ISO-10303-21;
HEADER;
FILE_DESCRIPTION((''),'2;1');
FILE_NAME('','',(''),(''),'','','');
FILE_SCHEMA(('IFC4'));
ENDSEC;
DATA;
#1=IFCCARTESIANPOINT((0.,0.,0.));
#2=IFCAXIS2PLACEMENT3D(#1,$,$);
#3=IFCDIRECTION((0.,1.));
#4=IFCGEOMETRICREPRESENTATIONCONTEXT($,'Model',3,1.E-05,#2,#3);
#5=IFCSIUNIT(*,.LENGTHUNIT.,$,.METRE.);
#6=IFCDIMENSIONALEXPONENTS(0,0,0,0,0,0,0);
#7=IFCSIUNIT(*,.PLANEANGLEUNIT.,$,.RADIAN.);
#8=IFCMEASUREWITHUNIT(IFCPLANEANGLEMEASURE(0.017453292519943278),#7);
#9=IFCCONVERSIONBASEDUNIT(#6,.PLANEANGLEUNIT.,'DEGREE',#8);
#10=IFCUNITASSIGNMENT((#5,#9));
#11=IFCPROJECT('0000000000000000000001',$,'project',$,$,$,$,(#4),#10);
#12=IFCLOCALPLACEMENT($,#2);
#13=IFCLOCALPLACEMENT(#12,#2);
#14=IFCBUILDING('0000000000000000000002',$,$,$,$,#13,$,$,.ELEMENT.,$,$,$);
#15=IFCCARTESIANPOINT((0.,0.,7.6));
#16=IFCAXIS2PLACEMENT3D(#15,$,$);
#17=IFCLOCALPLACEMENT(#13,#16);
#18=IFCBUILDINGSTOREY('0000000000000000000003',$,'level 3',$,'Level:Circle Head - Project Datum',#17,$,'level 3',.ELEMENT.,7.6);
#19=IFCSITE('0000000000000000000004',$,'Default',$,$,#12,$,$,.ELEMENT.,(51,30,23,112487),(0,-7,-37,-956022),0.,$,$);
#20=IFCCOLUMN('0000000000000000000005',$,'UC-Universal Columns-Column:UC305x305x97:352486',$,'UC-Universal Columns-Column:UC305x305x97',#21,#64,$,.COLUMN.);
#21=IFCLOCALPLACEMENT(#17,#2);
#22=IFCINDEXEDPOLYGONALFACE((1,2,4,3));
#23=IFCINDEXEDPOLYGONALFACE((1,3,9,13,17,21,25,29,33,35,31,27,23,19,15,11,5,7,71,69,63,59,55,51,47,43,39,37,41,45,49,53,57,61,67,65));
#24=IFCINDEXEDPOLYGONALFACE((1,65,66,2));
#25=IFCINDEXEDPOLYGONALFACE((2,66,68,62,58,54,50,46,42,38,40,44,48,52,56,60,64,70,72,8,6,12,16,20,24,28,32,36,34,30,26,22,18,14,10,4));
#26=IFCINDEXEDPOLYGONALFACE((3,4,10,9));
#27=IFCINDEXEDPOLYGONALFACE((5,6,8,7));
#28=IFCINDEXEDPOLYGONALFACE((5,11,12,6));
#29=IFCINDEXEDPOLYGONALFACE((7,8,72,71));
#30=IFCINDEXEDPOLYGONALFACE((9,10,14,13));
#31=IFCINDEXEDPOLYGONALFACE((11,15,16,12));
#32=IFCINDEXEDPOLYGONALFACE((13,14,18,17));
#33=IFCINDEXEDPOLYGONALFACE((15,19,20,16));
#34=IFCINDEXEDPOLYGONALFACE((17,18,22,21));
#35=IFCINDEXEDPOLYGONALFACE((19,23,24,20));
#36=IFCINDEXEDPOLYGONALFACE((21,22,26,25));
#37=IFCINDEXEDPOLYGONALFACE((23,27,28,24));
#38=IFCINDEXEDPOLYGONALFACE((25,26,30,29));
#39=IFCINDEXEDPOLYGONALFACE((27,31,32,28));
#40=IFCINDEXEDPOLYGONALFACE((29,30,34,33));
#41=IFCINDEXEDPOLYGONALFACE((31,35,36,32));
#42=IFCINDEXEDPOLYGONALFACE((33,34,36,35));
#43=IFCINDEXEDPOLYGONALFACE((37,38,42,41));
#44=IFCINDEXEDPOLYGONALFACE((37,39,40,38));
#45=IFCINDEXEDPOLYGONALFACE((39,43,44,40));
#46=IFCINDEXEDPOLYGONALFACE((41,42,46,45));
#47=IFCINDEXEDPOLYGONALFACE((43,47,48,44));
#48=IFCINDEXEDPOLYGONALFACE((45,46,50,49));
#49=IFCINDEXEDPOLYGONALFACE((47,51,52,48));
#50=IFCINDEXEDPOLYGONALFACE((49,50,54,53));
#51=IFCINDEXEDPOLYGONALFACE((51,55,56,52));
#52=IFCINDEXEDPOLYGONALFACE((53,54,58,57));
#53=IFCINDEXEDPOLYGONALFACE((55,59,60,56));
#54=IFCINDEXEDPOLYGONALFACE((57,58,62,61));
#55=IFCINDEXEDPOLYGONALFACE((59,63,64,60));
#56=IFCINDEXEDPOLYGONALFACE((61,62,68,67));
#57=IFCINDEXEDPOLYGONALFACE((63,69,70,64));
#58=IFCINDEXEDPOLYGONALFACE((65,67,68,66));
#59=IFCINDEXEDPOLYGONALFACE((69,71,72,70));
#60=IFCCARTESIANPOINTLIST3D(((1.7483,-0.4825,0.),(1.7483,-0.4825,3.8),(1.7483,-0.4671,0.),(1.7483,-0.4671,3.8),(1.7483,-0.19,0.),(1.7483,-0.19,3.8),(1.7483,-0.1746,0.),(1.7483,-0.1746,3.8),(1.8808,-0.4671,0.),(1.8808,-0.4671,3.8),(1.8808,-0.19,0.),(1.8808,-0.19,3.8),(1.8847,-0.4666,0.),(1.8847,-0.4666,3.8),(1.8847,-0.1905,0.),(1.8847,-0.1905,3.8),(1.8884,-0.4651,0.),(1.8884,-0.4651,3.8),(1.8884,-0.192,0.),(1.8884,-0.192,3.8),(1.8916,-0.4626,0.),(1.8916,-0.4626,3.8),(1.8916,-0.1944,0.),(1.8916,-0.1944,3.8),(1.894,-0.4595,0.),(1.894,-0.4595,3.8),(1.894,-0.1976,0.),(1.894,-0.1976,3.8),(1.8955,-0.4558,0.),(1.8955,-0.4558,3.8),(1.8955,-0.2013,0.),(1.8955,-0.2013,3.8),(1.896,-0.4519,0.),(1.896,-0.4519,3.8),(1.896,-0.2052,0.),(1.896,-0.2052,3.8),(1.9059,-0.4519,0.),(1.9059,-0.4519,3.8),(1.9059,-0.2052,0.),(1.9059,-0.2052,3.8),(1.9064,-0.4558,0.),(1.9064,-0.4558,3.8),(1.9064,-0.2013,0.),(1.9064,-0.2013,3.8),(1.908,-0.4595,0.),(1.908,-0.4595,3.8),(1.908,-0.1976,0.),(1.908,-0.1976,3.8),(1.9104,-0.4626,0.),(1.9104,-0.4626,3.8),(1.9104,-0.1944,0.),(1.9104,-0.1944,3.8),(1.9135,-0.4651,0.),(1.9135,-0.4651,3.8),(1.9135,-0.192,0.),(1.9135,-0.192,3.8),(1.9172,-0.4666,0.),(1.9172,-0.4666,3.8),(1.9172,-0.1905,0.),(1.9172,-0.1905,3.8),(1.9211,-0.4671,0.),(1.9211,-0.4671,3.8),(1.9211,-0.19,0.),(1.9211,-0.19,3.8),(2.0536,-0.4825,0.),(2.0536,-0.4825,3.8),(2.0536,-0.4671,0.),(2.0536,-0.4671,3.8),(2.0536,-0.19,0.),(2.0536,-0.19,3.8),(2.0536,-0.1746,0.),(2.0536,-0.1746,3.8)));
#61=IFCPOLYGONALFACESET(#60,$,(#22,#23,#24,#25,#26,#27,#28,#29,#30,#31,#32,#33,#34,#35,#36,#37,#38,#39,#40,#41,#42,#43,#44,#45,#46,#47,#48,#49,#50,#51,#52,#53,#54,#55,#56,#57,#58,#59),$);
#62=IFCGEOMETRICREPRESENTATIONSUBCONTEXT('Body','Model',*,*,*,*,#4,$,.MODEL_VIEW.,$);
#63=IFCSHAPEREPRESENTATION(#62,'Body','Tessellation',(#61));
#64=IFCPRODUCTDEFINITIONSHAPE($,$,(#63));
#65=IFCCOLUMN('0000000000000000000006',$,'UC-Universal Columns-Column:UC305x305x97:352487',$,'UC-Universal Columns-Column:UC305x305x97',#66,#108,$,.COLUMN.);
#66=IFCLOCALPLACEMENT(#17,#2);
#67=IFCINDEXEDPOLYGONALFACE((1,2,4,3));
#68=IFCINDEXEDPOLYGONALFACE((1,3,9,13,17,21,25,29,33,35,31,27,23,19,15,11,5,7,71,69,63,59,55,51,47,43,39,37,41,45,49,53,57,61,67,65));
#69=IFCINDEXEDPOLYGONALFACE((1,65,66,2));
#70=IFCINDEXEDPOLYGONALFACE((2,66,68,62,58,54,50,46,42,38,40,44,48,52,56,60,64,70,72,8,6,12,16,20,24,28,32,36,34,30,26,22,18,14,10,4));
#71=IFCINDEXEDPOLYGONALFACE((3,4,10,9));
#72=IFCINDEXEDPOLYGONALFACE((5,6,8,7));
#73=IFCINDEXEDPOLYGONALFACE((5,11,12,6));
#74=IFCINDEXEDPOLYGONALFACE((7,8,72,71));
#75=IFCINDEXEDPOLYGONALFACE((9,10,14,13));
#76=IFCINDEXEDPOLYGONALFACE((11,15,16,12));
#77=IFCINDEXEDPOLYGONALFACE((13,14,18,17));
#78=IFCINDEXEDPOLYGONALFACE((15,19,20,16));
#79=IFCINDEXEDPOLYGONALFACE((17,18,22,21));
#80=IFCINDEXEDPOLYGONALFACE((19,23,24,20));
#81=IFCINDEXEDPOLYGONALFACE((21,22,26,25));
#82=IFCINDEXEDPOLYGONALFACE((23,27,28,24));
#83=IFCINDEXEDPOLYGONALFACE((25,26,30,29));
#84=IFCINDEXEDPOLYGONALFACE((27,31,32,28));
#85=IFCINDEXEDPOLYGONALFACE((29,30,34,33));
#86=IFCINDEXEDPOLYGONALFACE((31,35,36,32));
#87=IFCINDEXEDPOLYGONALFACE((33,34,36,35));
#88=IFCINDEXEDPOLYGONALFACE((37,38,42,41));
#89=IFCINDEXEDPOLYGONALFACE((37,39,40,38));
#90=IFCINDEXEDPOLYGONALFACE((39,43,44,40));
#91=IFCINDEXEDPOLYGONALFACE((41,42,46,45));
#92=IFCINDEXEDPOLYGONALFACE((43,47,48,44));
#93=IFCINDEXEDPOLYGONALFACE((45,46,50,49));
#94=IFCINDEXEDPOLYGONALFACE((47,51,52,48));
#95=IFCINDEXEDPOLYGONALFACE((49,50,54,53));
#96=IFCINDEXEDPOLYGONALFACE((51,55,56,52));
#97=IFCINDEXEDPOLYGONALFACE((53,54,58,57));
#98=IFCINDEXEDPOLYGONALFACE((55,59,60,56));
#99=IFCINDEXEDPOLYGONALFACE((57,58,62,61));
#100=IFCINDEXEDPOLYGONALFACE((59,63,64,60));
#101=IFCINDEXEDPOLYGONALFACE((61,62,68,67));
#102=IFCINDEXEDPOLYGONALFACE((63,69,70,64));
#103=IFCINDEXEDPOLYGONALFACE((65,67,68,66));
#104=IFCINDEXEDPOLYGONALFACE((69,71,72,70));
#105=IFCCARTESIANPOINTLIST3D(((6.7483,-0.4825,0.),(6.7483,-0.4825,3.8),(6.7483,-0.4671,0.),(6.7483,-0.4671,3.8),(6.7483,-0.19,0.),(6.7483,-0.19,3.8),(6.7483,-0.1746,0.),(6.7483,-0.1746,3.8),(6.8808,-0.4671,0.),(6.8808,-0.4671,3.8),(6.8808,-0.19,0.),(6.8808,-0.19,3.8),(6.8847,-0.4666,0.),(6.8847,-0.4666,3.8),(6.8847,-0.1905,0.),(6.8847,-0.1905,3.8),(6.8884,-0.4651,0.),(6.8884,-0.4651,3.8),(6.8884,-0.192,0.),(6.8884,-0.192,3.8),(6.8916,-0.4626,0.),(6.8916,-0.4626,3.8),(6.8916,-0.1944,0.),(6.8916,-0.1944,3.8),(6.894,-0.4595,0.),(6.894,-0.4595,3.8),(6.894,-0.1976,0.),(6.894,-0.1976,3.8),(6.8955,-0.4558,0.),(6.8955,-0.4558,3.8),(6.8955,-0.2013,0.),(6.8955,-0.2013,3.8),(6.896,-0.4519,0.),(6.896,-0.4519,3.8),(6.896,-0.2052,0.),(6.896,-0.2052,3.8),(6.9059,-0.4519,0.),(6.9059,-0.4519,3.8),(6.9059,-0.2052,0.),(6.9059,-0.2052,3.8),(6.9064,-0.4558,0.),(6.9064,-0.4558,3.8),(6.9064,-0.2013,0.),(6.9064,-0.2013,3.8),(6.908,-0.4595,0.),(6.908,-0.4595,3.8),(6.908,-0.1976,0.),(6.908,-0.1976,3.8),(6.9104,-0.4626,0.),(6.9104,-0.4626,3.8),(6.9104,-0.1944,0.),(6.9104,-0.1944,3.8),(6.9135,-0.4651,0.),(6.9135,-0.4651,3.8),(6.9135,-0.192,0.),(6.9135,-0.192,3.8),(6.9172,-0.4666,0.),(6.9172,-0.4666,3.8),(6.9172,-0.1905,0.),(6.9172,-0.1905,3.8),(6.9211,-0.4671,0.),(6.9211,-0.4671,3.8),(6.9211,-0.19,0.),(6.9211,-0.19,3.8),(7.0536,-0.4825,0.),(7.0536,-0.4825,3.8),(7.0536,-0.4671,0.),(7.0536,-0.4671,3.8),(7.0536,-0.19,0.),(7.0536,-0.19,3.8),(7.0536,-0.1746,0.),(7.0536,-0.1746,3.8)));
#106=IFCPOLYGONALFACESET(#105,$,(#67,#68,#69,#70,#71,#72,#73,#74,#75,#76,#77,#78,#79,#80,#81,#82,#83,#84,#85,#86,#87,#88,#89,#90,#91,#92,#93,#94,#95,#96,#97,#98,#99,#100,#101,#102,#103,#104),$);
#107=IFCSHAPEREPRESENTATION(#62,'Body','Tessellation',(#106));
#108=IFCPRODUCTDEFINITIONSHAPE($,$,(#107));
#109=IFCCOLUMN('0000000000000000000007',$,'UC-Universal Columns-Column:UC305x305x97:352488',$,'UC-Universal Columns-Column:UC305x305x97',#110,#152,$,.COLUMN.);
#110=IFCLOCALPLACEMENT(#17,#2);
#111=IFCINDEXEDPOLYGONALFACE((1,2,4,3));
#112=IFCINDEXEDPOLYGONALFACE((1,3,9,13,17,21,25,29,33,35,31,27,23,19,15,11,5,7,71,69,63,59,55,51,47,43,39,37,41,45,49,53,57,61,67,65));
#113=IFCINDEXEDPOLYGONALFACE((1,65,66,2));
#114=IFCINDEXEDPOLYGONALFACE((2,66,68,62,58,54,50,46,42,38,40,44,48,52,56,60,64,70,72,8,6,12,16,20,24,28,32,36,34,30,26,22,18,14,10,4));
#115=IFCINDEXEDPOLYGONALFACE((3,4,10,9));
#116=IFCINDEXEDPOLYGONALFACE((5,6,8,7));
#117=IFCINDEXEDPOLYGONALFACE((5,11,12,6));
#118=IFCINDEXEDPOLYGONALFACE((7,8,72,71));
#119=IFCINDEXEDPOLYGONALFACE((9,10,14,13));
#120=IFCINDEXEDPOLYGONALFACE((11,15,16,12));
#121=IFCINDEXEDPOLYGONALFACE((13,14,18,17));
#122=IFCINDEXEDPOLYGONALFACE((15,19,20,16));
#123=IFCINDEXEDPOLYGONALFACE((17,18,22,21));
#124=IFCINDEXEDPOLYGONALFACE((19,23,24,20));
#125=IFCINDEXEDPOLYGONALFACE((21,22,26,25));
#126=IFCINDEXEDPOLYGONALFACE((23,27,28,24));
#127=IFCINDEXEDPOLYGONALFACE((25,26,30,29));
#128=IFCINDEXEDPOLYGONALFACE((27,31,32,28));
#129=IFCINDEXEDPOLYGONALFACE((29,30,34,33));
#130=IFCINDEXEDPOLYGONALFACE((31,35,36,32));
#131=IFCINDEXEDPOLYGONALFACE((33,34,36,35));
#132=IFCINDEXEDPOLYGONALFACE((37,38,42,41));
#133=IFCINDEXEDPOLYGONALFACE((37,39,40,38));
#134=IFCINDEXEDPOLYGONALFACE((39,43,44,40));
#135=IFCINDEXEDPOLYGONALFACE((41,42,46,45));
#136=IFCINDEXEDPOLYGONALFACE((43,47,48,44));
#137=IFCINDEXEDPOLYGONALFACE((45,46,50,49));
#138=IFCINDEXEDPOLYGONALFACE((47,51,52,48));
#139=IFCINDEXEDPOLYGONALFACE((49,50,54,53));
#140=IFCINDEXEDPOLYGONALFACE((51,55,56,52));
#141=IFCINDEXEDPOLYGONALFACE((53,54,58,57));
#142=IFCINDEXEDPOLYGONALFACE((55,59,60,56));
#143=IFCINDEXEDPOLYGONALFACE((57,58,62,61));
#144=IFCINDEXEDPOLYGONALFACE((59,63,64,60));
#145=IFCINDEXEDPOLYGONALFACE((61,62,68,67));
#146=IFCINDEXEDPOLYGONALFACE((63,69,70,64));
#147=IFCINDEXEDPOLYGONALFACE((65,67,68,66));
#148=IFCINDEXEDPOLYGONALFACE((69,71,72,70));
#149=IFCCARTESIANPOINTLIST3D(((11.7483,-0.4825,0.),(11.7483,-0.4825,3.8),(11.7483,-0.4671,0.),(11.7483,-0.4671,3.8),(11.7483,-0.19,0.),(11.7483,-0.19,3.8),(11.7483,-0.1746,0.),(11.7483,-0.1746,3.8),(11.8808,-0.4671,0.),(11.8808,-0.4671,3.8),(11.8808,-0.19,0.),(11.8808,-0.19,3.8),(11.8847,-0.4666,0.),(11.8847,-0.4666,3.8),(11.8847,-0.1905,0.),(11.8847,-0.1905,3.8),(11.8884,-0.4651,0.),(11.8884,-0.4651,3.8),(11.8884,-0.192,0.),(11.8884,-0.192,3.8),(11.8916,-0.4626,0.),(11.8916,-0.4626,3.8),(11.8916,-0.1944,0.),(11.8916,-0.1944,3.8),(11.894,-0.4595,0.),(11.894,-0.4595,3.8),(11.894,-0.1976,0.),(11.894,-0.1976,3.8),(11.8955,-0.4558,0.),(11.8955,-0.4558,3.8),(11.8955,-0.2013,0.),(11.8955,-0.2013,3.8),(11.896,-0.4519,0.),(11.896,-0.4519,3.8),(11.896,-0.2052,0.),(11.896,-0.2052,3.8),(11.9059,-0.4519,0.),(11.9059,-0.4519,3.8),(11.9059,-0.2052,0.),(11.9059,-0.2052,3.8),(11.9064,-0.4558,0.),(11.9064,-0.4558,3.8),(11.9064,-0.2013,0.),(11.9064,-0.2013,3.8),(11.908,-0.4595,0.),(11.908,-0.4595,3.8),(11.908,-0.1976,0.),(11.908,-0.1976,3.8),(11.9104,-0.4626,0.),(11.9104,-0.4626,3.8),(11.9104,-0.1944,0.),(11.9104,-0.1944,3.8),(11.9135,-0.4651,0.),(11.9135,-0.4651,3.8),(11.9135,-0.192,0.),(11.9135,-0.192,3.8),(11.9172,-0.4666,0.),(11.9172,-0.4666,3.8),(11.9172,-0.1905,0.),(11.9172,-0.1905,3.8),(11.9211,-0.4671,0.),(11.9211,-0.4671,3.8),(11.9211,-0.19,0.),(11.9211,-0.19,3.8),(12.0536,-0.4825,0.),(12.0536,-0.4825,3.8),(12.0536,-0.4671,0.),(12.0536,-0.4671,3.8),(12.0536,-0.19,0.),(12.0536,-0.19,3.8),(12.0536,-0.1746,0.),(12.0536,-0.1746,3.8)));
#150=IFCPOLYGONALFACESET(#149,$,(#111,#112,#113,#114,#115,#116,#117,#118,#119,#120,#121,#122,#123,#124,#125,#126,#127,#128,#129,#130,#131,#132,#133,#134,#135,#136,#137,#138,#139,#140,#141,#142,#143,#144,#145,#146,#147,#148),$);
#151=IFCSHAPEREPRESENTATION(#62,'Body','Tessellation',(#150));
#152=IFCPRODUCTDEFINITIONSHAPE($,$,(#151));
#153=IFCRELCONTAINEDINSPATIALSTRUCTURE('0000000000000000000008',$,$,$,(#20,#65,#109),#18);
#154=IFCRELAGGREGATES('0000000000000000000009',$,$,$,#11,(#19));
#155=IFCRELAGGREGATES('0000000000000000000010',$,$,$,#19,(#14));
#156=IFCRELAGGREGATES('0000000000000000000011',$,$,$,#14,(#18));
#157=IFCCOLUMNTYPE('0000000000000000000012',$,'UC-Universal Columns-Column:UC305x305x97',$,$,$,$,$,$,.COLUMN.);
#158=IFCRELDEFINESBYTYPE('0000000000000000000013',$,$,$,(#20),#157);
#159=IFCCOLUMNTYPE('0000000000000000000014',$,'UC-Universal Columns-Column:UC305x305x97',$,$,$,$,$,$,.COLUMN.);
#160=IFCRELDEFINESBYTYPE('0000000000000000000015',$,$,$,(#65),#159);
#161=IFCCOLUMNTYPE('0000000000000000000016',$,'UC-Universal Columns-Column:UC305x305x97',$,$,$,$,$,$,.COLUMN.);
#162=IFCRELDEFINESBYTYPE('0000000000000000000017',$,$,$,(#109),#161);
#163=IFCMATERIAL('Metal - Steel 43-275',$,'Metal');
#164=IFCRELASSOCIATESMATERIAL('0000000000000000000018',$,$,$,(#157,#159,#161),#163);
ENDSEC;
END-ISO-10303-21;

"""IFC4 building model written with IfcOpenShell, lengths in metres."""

from ifc_helpers import new_model, entity, si_unit, converted_unit, direction, frame, frame_2d, origin, place, context, subcontext, project, spatial, i_section, extrude, source, transform, mapped, material, material_profile, profile_set, type_object, type_shapes, element, save


model = new_model("IFC4")

# Units and contexts
model_context = context("Model", 3, precision=1e-05, world=origin(), true_north=direction((0.0, 1.0)))
body_context = subcontext(model_context, "Body", "Model", "MODEL_VIEW")
ifc_project = project(units=[si_unit("LENGTHUNIT", "METRE"), converted_unit("PLANEANGLEUNIT", "DEGREE", entity("IfcPlaneAngleMeasure", 0.017453292519943278), si_unit("PLANEANGLEUNIT", "RADIAN"), dimensions=[0, 0, 0, 0, 0, 0, 0])], contexts=[model_context])

# Site, building, storey
site_placement = place(None, origin())
site = spatial("IfcSite", under=ifc_project, at=site_placement, Name="Default", CompositionType="ELEMENT", RefLatitude=(51, 30, 23, 112487), RefLongitude=(0, -7, -37, -956022), RefElevation=0.0)
building_placement = place(site_placement, origin())
building = spatial("IfcBuilding", under=site, at=building_placement, CompositionType="ELEMENT")
storey_placement = place(building_placement, frame((0.0, 0.0, 7.6)))
storey = spatial("IfcBuildingStorey", under=building, at=storey_placement, Name="level 3", ObjectType="Level:Circle Head - Project Datum", LongName="level 3", CompositionType="ELEMENT", Elevation=7.6)

# Columns
ifc_material_1 = material(Name="Metal - Steel 43-275", Category="Metal")
ifc_material_profile_1 = material_profile(ifc_material_1, i_section(OverallWidth=0.3053, OverallDepth=0.3079, WebThickness=0.0099, FlangeThickness=0.0154, FilletRadius=0.0152, at=frame_2d((0.0, 0.0), x_axis=(1.0, 0.0))), Name="UC305x305x97")
ifc_profile_set_1 = profile_set([ifc_material_profile_1], Name="UC305x305x97")
column_type_1 = type_object("IfcColumnType", Name="UC-Universal Columns-Column:UC305x305x97", PredefinedType="COLUMN", material=ifc_profile_set_1)
shared_shape_1 = source(origin(), body_context, "Body", "SweptSolid", [
    extrude(i_section(OverallWidth=0.3053, OverallDepth=0.3079, WebThickness=0.0099, FlangeThickness=0.0154, FilletRadius=0.0152, at=frame_2d((0.0, 0.0), x_axis=(1.0, 0.0))), frame((1.901, -0.3285, 7.6), z_axis=(0.0, 0.0, 1.0), x_axis=(-1.0, 0.0, 0.0)), (0.0, 0.0, 1.0), 3.8),
])
type_shapes(column_type_1, [shared_shape_1])
column_1_placement = place(storey_placement, frame((0.0, 0.0, -7.6)))
element("IfcColumn", 1, at=column_1_placement, inside=storey, type_object=column_type_1, Name="UC-Universal Columns-Column:UC305x305x97:352486", ObjectType="UC-Universal Columns-Column:UC305x305x97", PredefinedType="COLUMN", context=body_context, shape_type="MappedRepresentation", body=[
    mapped(shared_shape_1, transform((0.0, 0.0, 0.0), scale=1.0)),
])
column_type_2 = type_object("IfcColumnType", Name="UC-Universal Columns-Column:UC305x305x97", PredefinedType="COLUMN", material=ifc_profile_set_1)
shared_shape_2 = source(origin(), body_context, "Body", "SweptSolid", [
    extrude(i_section(OverallWidth=0.3053, OverallDepth=0.3079, WebThickness=0.0099, FlangeThickness=0.0154, FilletRadius=0.0152, at=frame_2d((0.0, 0.0), x_axis=(1.0, 0.0))), frame((6.901, -0.3285, 7.6), z_axis=(0.0, 0.0, 1.0), x_axis=(-1.0, 0.0, 0.0)), (0.0, 0.0, 1.0), 3.8),
])
type_shapes(column_type_2, [shared_shape_2])
column_2_placement = place(storey_placement, frame((0.0, 0.0, -7.6)))
element("IfcColumn", 2, at=column_2_placement, inside=storey, type_object=column_type_2, Name="UC-Universal Columns-Column:UC305x305x97:352487", ObjectType="UC-Universal Columns-Column:UC305x305x97", PredefinedType="COLUMN", context=body_context, shape_type="MappedRepresentation", body=[
    mapped(shared_shape_2, transform((0.0, 0.0, 0.0), scale=1.0)),
])
column_type_3 = type_object("IfcColumnType", Name="UC-Universal Columns-Column:UC305x305x97", PredefinedType="COLUMN", material=ifc_profile_set_1)
shared_shape_3 = source(origin(), body_context, "Body", "SweptSolid", [
    extrude(i_section(OverallWidth=0.3053, OverallDepth=0.3079, WebThickness=0.0099, FlangeThickness=0.0154, FilletRadius=0.0152, at=frame_2d((0.0, 0.0), x_axis=(1.0, 0.0))), frame((11.901, -0.3285, 7.6), z_axis=(0.0, 0.0, 1.0), x_axis=(-1.0, 0.0, 0.0)), (0.0, 0.0, 1.0), 3.8),
])
type_shapes(column_type_3, [shared_shape_3])
column_3_placement = place(storey_placement, frame((0.0, 0.0, -7.6)))
element("IfcColumn", 3, at=column_3_placement, inside=storey, type_object=column_type_3, Name="UC-Universal Columns-Column:UC305x305x97:352488", ObjectType="UC-Universal Columns-Column:UC305x305x97", PredefinedType="COLUMN", context=body_context, shape_type="MappedRepresentation", body=[
    mapped(shared_shape_3, transform((0.0, 0.0, 0.0), scale=1.0)),
])

save(model, "model.ifc")
